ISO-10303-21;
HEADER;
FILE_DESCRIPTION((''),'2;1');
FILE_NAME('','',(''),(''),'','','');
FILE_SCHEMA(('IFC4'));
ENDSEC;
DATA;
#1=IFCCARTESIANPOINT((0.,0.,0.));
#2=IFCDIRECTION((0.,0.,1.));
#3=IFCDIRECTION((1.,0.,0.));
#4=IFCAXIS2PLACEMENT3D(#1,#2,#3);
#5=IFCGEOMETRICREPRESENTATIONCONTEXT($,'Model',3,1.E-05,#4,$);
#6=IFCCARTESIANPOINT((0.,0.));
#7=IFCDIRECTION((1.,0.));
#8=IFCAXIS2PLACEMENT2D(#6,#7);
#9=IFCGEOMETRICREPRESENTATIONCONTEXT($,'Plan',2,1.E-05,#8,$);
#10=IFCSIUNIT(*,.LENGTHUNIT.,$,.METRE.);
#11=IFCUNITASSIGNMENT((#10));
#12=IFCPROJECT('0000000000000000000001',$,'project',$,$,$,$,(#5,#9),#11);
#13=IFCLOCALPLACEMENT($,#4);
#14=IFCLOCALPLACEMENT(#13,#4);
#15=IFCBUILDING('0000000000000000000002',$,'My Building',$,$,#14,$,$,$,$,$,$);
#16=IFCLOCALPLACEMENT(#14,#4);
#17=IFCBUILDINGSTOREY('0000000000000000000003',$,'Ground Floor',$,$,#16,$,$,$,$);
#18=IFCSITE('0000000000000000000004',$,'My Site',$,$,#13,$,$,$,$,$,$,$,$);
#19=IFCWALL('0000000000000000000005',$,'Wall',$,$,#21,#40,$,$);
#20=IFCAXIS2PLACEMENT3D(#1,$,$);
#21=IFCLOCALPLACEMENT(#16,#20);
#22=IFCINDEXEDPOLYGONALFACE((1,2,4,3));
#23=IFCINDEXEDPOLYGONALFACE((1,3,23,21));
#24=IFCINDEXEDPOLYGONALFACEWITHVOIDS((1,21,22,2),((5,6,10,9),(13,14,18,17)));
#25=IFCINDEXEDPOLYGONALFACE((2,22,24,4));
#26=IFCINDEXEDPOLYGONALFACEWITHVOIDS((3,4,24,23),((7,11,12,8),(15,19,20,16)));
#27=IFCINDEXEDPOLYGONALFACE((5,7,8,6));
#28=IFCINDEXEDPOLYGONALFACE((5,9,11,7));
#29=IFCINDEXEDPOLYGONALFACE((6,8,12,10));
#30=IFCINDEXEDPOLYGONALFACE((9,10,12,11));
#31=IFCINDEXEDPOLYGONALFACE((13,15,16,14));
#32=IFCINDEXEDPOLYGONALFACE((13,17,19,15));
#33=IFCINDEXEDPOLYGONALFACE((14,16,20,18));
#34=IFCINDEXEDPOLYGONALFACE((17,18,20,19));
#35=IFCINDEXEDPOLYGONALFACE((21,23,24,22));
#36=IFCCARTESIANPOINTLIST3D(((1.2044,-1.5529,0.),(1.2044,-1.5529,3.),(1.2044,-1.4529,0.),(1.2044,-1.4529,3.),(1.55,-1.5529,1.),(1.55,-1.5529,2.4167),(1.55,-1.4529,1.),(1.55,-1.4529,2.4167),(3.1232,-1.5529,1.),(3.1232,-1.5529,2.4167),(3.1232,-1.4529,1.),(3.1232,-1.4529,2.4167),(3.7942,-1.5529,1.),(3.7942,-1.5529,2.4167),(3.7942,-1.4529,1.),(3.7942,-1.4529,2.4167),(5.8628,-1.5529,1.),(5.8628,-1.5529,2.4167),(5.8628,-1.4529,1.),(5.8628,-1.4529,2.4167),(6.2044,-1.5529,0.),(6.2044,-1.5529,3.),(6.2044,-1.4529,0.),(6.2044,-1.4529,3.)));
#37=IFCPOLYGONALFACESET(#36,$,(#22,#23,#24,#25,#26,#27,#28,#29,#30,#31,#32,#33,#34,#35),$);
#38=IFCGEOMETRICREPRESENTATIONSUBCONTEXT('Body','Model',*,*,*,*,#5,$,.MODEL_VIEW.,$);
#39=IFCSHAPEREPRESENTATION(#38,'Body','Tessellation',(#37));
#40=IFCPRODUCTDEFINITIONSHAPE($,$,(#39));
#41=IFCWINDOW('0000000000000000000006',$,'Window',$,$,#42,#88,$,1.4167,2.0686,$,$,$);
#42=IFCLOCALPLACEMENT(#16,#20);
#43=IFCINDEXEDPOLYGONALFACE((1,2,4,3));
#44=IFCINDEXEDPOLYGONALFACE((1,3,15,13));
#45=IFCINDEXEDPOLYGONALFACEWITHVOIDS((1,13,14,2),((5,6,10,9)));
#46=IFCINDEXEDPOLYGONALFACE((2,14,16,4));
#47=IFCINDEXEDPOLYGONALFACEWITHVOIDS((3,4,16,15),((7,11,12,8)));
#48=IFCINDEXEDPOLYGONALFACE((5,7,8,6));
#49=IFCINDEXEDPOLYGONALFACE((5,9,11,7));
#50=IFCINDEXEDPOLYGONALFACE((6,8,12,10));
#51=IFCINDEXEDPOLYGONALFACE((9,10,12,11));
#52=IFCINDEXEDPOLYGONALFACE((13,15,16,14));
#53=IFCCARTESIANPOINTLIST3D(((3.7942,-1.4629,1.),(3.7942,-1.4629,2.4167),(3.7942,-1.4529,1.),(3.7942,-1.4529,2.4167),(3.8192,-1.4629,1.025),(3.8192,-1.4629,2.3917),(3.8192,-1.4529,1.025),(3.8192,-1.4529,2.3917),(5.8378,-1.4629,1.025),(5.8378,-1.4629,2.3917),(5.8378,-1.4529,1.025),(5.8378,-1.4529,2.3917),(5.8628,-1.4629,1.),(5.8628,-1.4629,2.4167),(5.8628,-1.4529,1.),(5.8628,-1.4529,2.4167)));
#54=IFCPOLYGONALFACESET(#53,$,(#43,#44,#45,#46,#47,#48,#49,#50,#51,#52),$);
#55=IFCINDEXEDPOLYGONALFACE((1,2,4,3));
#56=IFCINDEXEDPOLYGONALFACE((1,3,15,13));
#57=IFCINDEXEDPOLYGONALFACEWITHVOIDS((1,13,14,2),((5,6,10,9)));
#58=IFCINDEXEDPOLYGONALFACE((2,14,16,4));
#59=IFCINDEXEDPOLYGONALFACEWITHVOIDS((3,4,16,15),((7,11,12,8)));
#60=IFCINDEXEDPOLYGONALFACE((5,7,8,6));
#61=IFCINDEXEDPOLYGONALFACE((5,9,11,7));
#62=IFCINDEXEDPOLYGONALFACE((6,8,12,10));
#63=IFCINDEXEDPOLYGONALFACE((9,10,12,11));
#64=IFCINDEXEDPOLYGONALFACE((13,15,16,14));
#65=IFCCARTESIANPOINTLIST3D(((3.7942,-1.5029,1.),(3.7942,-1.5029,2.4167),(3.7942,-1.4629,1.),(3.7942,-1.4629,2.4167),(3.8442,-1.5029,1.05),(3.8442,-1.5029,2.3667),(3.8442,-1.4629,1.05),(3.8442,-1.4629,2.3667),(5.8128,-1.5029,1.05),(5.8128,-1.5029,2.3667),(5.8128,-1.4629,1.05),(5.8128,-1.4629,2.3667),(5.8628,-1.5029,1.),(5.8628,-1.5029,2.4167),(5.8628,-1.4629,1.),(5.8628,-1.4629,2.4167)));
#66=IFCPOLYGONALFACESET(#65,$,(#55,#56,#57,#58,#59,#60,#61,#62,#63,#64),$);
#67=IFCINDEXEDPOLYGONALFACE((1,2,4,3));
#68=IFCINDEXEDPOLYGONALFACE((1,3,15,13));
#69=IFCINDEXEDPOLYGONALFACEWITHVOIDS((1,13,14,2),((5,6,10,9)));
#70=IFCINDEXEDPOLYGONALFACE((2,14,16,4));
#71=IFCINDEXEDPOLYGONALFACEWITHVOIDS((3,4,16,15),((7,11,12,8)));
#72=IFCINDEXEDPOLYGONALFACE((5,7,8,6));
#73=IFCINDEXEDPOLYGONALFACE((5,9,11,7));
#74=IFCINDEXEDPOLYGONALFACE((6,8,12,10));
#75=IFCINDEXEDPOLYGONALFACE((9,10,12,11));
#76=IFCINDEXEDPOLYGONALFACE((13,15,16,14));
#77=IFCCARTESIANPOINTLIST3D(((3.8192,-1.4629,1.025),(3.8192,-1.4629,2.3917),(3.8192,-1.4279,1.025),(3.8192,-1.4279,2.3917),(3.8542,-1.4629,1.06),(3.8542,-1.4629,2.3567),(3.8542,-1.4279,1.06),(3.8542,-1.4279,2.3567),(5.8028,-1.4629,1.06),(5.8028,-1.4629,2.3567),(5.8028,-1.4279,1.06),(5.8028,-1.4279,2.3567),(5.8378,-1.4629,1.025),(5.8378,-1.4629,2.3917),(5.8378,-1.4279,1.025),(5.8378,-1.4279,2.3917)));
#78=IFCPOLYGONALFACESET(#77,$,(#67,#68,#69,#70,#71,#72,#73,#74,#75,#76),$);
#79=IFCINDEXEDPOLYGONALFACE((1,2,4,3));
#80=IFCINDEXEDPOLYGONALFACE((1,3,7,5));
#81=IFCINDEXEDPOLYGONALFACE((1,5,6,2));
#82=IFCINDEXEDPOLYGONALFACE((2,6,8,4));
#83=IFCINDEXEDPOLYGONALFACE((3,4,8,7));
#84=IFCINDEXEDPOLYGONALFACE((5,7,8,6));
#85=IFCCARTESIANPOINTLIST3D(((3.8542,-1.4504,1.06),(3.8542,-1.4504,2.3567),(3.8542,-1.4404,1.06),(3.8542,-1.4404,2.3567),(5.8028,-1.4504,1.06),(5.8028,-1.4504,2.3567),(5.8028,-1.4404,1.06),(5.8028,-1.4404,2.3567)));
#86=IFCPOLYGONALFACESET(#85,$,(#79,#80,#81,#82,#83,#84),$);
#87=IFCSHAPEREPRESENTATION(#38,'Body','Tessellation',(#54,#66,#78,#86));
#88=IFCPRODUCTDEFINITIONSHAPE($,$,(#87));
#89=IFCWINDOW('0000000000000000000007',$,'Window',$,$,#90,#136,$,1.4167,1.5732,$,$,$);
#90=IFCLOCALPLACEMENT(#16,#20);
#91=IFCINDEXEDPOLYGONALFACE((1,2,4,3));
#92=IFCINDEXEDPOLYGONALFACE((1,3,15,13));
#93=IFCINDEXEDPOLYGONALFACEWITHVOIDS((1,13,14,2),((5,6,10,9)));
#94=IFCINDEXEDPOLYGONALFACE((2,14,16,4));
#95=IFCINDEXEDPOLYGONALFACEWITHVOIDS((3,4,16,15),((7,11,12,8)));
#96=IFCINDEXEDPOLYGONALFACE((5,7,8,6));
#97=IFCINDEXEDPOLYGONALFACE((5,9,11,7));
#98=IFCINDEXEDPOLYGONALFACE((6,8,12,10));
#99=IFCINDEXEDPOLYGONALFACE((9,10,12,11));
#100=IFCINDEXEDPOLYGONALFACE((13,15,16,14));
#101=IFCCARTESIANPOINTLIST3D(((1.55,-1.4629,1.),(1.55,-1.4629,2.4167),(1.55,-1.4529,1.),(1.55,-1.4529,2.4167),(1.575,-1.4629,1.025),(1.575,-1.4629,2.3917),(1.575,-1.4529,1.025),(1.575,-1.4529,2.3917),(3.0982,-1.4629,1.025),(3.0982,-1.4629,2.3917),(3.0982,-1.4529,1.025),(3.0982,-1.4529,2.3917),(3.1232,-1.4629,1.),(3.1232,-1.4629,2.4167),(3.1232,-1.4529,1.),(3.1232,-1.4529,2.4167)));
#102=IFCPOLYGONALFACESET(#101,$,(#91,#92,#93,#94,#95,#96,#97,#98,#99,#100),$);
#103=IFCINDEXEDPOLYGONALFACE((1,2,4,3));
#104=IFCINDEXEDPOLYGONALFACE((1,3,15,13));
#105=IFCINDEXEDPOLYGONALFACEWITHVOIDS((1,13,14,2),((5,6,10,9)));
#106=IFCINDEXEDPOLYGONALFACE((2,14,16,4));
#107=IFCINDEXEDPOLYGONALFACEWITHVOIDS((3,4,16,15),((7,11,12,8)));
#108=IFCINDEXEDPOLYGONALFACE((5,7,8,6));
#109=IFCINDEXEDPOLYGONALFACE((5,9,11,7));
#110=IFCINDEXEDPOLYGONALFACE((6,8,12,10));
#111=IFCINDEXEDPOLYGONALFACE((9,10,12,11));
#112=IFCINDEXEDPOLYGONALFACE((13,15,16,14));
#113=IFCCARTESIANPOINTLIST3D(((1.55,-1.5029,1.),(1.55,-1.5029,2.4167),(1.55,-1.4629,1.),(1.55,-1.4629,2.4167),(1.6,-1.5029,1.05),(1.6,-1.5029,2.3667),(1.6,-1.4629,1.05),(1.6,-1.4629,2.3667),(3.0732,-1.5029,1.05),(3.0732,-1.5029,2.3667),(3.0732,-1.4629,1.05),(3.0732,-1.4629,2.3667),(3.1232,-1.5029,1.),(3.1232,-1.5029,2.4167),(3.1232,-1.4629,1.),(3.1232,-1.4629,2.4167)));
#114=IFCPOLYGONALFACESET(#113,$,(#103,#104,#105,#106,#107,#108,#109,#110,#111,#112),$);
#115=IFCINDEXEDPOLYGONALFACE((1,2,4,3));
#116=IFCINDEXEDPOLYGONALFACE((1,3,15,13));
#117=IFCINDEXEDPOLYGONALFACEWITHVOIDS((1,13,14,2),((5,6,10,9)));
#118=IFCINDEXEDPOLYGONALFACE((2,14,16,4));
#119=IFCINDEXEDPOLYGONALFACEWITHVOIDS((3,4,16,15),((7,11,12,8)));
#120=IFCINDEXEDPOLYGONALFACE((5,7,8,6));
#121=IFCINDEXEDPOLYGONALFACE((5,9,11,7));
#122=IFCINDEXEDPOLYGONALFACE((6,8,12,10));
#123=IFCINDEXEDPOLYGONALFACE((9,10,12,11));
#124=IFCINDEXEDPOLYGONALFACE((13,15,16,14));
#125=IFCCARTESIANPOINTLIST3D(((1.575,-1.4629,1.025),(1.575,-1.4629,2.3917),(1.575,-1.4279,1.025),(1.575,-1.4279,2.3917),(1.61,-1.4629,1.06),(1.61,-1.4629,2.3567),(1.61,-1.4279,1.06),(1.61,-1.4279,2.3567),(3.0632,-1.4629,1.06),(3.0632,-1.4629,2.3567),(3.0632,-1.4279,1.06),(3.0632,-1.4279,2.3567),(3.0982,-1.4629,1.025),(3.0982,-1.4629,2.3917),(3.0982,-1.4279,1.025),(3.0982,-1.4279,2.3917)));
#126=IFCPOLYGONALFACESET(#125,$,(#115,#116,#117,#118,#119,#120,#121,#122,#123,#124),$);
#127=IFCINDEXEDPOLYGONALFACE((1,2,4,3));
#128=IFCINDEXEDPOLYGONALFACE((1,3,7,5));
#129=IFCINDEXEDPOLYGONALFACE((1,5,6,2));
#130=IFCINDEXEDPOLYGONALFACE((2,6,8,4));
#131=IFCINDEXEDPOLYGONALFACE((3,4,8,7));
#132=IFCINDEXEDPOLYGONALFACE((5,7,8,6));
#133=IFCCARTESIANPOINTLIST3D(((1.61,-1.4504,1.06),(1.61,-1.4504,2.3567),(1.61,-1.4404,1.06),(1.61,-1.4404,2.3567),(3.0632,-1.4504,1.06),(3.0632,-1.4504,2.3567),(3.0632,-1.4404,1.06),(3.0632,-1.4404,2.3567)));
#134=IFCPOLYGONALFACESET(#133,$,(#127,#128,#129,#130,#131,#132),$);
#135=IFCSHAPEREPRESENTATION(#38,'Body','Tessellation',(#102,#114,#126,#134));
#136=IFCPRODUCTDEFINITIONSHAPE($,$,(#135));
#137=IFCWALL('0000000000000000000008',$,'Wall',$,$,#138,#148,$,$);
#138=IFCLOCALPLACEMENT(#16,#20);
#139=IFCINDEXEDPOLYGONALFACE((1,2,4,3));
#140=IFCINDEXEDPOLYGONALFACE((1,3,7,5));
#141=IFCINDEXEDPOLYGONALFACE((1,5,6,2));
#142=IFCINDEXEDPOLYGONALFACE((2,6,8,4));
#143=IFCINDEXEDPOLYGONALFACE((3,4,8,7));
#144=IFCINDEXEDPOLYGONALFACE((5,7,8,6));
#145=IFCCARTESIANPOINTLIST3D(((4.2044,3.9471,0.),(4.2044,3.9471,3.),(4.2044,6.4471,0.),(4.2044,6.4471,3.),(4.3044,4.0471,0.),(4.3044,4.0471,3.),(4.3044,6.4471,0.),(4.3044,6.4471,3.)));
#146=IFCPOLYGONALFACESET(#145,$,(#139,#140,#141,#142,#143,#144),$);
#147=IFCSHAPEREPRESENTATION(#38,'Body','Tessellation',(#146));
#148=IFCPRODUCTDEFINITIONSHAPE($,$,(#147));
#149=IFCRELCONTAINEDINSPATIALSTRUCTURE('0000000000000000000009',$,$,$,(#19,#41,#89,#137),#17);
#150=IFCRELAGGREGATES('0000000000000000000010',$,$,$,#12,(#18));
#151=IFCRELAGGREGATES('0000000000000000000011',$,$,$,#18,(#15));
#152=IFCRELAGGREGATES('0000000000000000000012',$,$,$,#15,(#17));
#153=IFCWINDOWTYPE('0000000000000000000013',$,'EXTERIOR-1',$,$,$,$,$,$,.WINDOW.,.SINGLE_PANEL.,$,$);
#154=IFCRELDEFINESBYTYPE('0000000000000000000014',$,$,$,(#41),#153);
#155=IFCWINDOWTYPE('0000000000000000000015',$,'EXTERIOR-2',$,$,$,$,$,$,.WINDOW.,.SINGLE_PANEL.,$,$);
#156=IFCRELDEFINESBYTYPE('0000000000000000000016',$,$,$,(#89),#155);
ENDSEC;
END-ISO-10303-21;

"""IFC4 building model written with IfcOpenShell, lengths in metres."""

from ifc_helpers import new_model, entity, si_unit, frame, origin_with_axes, origin_2d_with_axis, place, context, subcontext, project, spatial, line, indexed_curve, outline, extrude, shape, source, transform, mapped, type_object, type_shapes, element, fill, save


model = new_model("IFC4")

# Units and contexts
model_context = context("Model", 3, precision=1e-05, world=origin_with_axes())
plan_context = context("Plan", 2, precision=1e-05, world=origin_2d_with_axis())
body_context_1 = subcontext(model_context, "Body", "Model", "MODEL_VIEW")
body_context_2 = subcontext(plan_context, "Body", "Plan", "PLAN_VIEW")
ifc_project = project(units=[si_unit("LENGTHUNIT", "METRE")], contexts=[model_context, plan_context])

# Site, building, storey
site_placement = place(None, origin_with_axes())
site = spatial("IfcSite", under=ifc_project, at=site_placement, Name="My Site")
building_placement = place(site_placement, origin_with_axes())
building = spatial("IfcBuilding", under=site, at=building_placement, Name="My Building")
storey_placement = place(building_placement, origin_with_axes())
storey = spatial("IfcBuildingStorey", under=building, at=storey_placement, Name="Ground Floor")

# Wall, openings, windows
wall_1_placement = place(storey_placement, frame((1.2044, -1.5529, 0.0), z_axis=(0.0, 0.0, 1.0), x_axis=(1.0, 0.0, 0.0)))
wall_1 = element("IfcWall", 1, at=wall_1_placement, inside=storey, Name="Wall", context=body_context_1, shape_type="SweptSolid", body=[
    extrude(outline(indexed_curve([(0.0, 0.0), (0.0, 0.1), (5.0, 0.1), (5.0, 0.0)], segments=[line(1, 2, 3, 4, 1)])), origin_with_axes(), (0.0, 0.0, 1.0), 3.0),
])
shared_shape_1 = source(origin_with_axes(), body_context_1, "Body", "SweptSolid", [
    extrude(outline(indexed_curve([(0.0, 0.0), (2.0686, 0.0), (2.0686, 1.4167), (0.0, 1.4167)], segments=[line(1, 2, 3, 4, 1)])), frame((0.0, -0.6, 0.0), z_axis=(0.0, -1.0, 0.0), x_axis=(1.0, 0.0, 0.0)), (0.0, 0.0, -1.0), 1.2),
])
opening_1_placement = place(wall_1_placement, frame((2.5898, 0.0, 1.0), z_axis=(0.0, 0.0, 1.0), x_axis=(1.0, 0.0, 0.0)))
opening_1 = element("IfcOpeningElement", 2, at=opening_1_placement, cuts=wall_1, PredefinedType="OPENING", context=body_context_1, shape_type="MappedRepresentation", body=[
    mapped(shared_shape_1, transform((0.0, 0.0, 0.0), x_axis=(1.0, 0.0, 0.0), y_axis=(0.0, 1.0, 0.0), z_axis=(0.0, 0.0, 1.0), scale=1.0)),
])
shared_shape_2 = source(origin_with_axes(), body_context_1, "Body", "SweptSolid", [
    extrude(outline(indexed_curve([(0.0, 0.0), (1.5732, 0.0), (1.5732, 1.4167), (0.0, 1.4167)], segments=[line(1, 2, 3, 4, 1)])), frame((0.0, -0.6, 0.0), z_axis=(0.0, -1.0, 0.0), x_axis=(1.0, 0.0, 0.0)), (0.0, 0.0, -1.0), 1.2),
])
opening_2_placement = place(wall_1_placement, frame((0.3455, 0.0, 1.0), z_axis=(0.0, 0.0, 1.0), x_axis=(1.0, 0.0, 0.0)))
opening_2 = element("IfcOpeningElement", 3, at=opening_2_placement, cuts=wall_1, PredefinedType="OPENING", context=body_context_1, shape_type="MappedRepresentation", body=[
    mapped(shared_shape_2, transform((0.0, 0.0, 0.0), x_axis=(1.0, 0.0, 0.0), y_axis=(0.0, 1.0, 0.0), z_axis=(0.0, 0.0, 1.0), scale=1.0)),
])
window_type_1 = type_object("IfcWindowType", Name="EXTERIOR-1", PartitioningType="SINGLE_PANEL", PredefinedType="WINDOW")
shared_shape_3 = source(origin_with_axes(), body_context_1, "Body", "SweptSolid", [
    extrude(outline(indexed_curve([(0.0, 0.0), (2.0686, 0.0), (2.0686, 1.4167), (0.0, 1.4167)], segments=[line(1, 2, 3, 4, 1)]), holes=[indexed_curve([(0.025, 0.025), (2.0436, 0.025), (2.0436, 1.3917), (0.025, 1.3917)], segments=[line(1, 2, 3, 4, 1)])]), frame((0.0, 0.09, 0.0), z_axis=(0.0, -1.0, 0.0), x_axis=(1.0, 0.0, 0.0)), (0.0, 0.0, -1.0), 0.01),
    extrude(outline(indexed_curve([(0.0, 0.0), (2.0686, 0.0), (2.0686, 1.4167), (0.0, 1.4167)], segments=[line(1, 2, 3, 4, 1)]), holes=[indexed_curve([(0.05, 0.05), (2.0186, 0.05), (2.0186, 1.3667), (0.05, 1.3667)], segments=[line(1, 2, 3, 4, 1)])]), frame((0.0, 0.05, 0.0), z_axis=(0.0, -1.0, 0.0), x_axis=(1.0, 0.0, 0.0)), (0.0, 0.0, -1.0), 0.04),
    extrude(outline(indexed_curve([(0.0, 0.0), (2.0186, 0.0), (2.0186, 1.3667), (0.0, 1.3667)], segments=[line(1, 2, 3, 4, 1)]), holes=[indexed_curve([(0.035, 0.035), (1.9836, 0.035), (1.9836, 1.3317), (0.035, 1.3317)], segments=[line(1, 2, 3, 4, 1)])]), frame((0.025, 0.09, 0.025), z_axis=(0.0, -1.0, 0.0), x_axis=(1.0, 0.0, 0.0)), (0.0, 0.0, -1.0), 0.035),
    extrude(outline(indexed_curve([(0.035, 0.035), (1.9836, 0.035), (1.9836, 1.3317), (0.035, 1.3317)], segments=[line(1, 2, 3, 4, 1)])), frame((0.025, 0.1025, 0.025), z_axis=(0.0, -1.0, 0.0), x_axis=(1.0, 0.0, 0.0)), (0.0, 0.0, -1.0), 0.01),
])
shared_shape_4 = source(origin_with_axes(), body_context_2, "Body", "Curve2D", [
    entity("IfcIndexedPolyCurve", entity("IfcCartesianPointList2D", [[0.05, 0.05], [2.0186, 0.05]])),
    entity("IfcIndexedPolyCurve", entity("IfcCartesianPointList2D", [[0.0, 0.1], [0.025, 0.1], [0.025, 0.09], [0.05, 0.09], [0.05, 0.05], [0.0, 0.05]]), [entity("IfcLineIndex", [1, 2, 3, 4, 5, 6, 1])]),
    entity("IfcIndexedPolyCurve", entity("IfcCartesianPointList2D", [[2.0686, 0.1], [2.0436, 0.1], [2.0436, 0.09], [2.0186, 0.09], [2.0186, 0.05], [2.0686, 0.05]]), [entity("IfcLineIndex", [1, 2, 3, 4, 5, 6, 1])]),
    entity("IfcIndexedPolyCurve", entity("IfcCartesianPointList2D", [[0.025, 0.09], [0.06, 0.09], [0.06, 0.125], [0.025, 0.125]]), [entity("IfcLineIndex", [1, 2, 3, 4, 1])]),
    entity("IfcIndexedPolyCurve", entity("IfcCartesianPointList2D", [[2.0436, 0.09], [2.0086, 0.09], [2.0086, 0.125], [2.0436, 0.125]]), [entity("IfcLineIndex", [1, 2, 3, 4, 1])]),
    entity("IfcIndexedPolyCurve", entity("IfcCartesianPointList2D", [[0.06, 0.09], [2.0086, 0.09]])),
    entity("IfcIndexedPolyCurve", entity("IfcCartesianPointList2D", [[0.06, 0.125], [2.0086, 0.125]])),
    entity("IfcIndexedPolyCurve", entity("IfcCartesianPointList2D", [[0.06, 0.1075], [2.0086, 0.1075]])),
])
type_shapes(window_type_1, [shared_shape_3, shared_shape_4])
window_1_placement = place(opening_1_placement, origin_with_axes())
window_1 = element("IfcWindow", 4, at=window_1_placement, inside=storey, type_object=window_type_1, Name="Window", OverallHeight=1.4167, OverallWidth=2.0686, shapes=[
    shape(body_context_1, "Body", "MappedRepresentation", [mapped(shared_shape_3, transform((0.0, 0.0, 0.0), x_axis=(1.0, 0.0, 0.0), y_axis=(0.0, 1.0, 0.0), z_axis=(0.0, 0.0, 1.0), scale=1.0))]),
    shape(body_context_2, "Body", "MappedRepresentation", [mapped(shared_shape_4, transform((0.0, 0.0, 0.0), x_axis=(1.0, 0.0, 0.0), y_axis=(0.0, 1.0, 0.0), z_axis=(0.0, 0.0, 1.0), scale=1.0))]),
])
fill(opening_1, window_1)
window_type_2 = type_object("IfcWindowType", Name="EXTERIOR-2", PartitioningType="SINGLE_PANEL", PredefinedType="WINDOW")
shared_shape_5 = source(origin_with_axes(), body_context_1, "Body", "SweptSolid", [
    extrude(outline(indexed_curve([(0.0, 0.0), (1.5732, 0.0), (1.5732, 1.4167), (0.0, 1.4167)], segments=[line(1, 2, 3, 4, 1)]), holes=[indexed_curve([(0.025, 0.025), (1.5482, 0.025), (1.5482, 1.3917), (0.025, 1.3917)], segments=[line(1, 2, 3, 4, 1)])]), frame((0.0, 0.09, 0.0), z_axis=(0.0, -1.0, 0.0), x_axis=(1.0, 0.0, 0.0)), (0.0, 0.0, -1.0), 0.01),
    extrude(outline(indexed_curve([(0.0, 0.0), (1.5732, 0.0), (1.5732, 1.4167), (0.0, 1.4167)], segments=[line(1, 2, 3, 4, 1)]), holes=[indexed_curve([(0.05, 0.05), (1.5232, 0.05), (1.5232, 1.3667), (0.05, 1.3667)], segments=[line(1, 2, 3, 4, 1)])]), frame((0.0, 0.05, 0.0), z_axis=(0.0, -1.0, 0.0), x_axis=(1.0, 0.0, 0.0)), (0.0, 0.0, -1.0), 0.04),
    extrude(outline(indexed_curve([(0.0, 0.0), (1.5232, 0.0), (1.5232, 1.3667), (0.0, 1.3667)], segments=[line(1, 2, 3, 4, 1)]), holes=[indexed_curve([(0.035, 0.035), (1.4882, 0.035), (1.4882, 1.3317), (0.035, 1.3317)], segments=[line(1, 2, 3, 4, 1)])]), frame((0.025, 0.09, 0.025), z_axis=(0.0, -1.0, 0.0), x_axis=(1.0, 0.0, 0.0)), (0.0, 0.0, -1.0), 0.035),
    extrude(outline(indexed_curve([(0.035, 0.035), (1.4882, 0.035), (1.4882, 1.3317), (0.035, 1.3317)], segments=[line(1, 2, 3, 4, 1)])), frame((0.025, 0.1025, 0.025), z_axis=(0.0, -1.0, 0.0), x_axis=(1.0, 0.0, 0.0)), (0.0, 0.0, -1.0), 0.01),
])
shared_shape_6 = source(origin_with_axes(), body_context_2, "Body", "Curve2D", [
    entity("IfcIndexedPolyCurve", entity("IfcCartesianPointList2D", [[0.05, 0.05], [1.5232, 0.05]])),
    entity("IfcIndexedPolyCurve", entity("IfcCartesianPointList2D", [[0.0, 0.1], [0.025, 0.1], [0.025, 0.09], [0.05, 0.09], [0.05, 0.05], [0.0, 0.05]]), [entity("IfcLineIndex", [1, 2, 3, 4, 5, 6, 1])]),
    entity("IfcIndexedPolyCurve", entity("IfcCartesianPointList2D", [[1.5732, 0.1], [1.5482, 0.1], [1.5482, 0.09], [1.5232, 0.09], [1.5232, 0.05], [1.5732, 0.05]]), [entity("IfcLineIndex", [1, 2, 3, 4, 5, 6, 1])]),
    entity("IfcIndexedPolyCurve", entity("IfcCartesianPointList2D", [[0.025, 0.09], [0.06, 0.09], [0.06, 0.125], [0.025, 0.125]]), [entity("IfcLineIndex", [1, 2, 3, 4, 1])]),
    entity("IfcIndexedPolyCurve", entity("IfcCartesianPointList2D", [[1.5482, 0.09], [1.5132, 0.09], [1.5132, 0.125], [1.5482, 0.125]]), [entity("IfcLineIndex", [1, 2, 3, 4, 1])]),
    entity("IfcIndexedPolyCurve", entity("IfcCartesianPointList2D", [[0.06, 0.09], [1.5132, 0.09]])),
    entity("IfcIndexedPolyCurve", entity("IfcCartesianPointList2D", [[0.06, 0.125], [1.5132, 0.125]])),
    entity("IfcIndexedPolyCurve", entity("IfcCartesianPointList2D", [[0.06, 0.1075], [1.5132, 0.1075]])),
])
type_shapes(window_type_2, [shared_shape_5, shared_shape_6])
window_2_placement = place(opening_2_placement, origin_with_axes())
window_2 = element("IfcWindow", 5, at=window_2_placement, inside=storey, type_object=window_type_2, Name="Window", OverallHeight=1.4167, OverallWidth=1.5732, shapes=[
    shape(body_context_1, "Body", "MappedRepresentation", [mapped(shared_shape_5, transform((0.0, 0.0, 0.0), x_axis=(1.0, 0.0, 0.0), y_axis=(0.0, 1.0, 0.0), z_axis=(0.0, 0.0, 1.0), scale=1.0))]),
    shape(body_context_2, "Body", "MappedRepresentation", [mapped(shared_shape_6, transform((0.0, 0.0, 0.0), x_axis=(1.0, 0.0, 0.0), y_axis=(0.0, 1.0, 0.0), z_axis=(0.0, 0.0, 1.0), scale=1.0))]),
])
fill(opening_2, window_2)

# Wall
wall_2_placement = place(storey_placement, frame((4.2044, 6.4471, 0.0), z_axis=(0.0, 0.0, 1.0), x_axis=(0.0, -1.0, 0.0)))
element("IfcWall", 6, at=wall_2_placement, inside=storey, Name="Wall", context=body_context_1, shape_type="SweptSolid", body=[
    extrude(outline(indexed_curve([(0.0, 0.0), (0.0, 0.1), (2.4, 0.1), (2.5, 0.0)], segments=[line(1, 2, 3, 4, 1)])), origin_with_axes(), (0.0, 0.0, 1.0), 3.0),
])

save(model, "model.ifc")
